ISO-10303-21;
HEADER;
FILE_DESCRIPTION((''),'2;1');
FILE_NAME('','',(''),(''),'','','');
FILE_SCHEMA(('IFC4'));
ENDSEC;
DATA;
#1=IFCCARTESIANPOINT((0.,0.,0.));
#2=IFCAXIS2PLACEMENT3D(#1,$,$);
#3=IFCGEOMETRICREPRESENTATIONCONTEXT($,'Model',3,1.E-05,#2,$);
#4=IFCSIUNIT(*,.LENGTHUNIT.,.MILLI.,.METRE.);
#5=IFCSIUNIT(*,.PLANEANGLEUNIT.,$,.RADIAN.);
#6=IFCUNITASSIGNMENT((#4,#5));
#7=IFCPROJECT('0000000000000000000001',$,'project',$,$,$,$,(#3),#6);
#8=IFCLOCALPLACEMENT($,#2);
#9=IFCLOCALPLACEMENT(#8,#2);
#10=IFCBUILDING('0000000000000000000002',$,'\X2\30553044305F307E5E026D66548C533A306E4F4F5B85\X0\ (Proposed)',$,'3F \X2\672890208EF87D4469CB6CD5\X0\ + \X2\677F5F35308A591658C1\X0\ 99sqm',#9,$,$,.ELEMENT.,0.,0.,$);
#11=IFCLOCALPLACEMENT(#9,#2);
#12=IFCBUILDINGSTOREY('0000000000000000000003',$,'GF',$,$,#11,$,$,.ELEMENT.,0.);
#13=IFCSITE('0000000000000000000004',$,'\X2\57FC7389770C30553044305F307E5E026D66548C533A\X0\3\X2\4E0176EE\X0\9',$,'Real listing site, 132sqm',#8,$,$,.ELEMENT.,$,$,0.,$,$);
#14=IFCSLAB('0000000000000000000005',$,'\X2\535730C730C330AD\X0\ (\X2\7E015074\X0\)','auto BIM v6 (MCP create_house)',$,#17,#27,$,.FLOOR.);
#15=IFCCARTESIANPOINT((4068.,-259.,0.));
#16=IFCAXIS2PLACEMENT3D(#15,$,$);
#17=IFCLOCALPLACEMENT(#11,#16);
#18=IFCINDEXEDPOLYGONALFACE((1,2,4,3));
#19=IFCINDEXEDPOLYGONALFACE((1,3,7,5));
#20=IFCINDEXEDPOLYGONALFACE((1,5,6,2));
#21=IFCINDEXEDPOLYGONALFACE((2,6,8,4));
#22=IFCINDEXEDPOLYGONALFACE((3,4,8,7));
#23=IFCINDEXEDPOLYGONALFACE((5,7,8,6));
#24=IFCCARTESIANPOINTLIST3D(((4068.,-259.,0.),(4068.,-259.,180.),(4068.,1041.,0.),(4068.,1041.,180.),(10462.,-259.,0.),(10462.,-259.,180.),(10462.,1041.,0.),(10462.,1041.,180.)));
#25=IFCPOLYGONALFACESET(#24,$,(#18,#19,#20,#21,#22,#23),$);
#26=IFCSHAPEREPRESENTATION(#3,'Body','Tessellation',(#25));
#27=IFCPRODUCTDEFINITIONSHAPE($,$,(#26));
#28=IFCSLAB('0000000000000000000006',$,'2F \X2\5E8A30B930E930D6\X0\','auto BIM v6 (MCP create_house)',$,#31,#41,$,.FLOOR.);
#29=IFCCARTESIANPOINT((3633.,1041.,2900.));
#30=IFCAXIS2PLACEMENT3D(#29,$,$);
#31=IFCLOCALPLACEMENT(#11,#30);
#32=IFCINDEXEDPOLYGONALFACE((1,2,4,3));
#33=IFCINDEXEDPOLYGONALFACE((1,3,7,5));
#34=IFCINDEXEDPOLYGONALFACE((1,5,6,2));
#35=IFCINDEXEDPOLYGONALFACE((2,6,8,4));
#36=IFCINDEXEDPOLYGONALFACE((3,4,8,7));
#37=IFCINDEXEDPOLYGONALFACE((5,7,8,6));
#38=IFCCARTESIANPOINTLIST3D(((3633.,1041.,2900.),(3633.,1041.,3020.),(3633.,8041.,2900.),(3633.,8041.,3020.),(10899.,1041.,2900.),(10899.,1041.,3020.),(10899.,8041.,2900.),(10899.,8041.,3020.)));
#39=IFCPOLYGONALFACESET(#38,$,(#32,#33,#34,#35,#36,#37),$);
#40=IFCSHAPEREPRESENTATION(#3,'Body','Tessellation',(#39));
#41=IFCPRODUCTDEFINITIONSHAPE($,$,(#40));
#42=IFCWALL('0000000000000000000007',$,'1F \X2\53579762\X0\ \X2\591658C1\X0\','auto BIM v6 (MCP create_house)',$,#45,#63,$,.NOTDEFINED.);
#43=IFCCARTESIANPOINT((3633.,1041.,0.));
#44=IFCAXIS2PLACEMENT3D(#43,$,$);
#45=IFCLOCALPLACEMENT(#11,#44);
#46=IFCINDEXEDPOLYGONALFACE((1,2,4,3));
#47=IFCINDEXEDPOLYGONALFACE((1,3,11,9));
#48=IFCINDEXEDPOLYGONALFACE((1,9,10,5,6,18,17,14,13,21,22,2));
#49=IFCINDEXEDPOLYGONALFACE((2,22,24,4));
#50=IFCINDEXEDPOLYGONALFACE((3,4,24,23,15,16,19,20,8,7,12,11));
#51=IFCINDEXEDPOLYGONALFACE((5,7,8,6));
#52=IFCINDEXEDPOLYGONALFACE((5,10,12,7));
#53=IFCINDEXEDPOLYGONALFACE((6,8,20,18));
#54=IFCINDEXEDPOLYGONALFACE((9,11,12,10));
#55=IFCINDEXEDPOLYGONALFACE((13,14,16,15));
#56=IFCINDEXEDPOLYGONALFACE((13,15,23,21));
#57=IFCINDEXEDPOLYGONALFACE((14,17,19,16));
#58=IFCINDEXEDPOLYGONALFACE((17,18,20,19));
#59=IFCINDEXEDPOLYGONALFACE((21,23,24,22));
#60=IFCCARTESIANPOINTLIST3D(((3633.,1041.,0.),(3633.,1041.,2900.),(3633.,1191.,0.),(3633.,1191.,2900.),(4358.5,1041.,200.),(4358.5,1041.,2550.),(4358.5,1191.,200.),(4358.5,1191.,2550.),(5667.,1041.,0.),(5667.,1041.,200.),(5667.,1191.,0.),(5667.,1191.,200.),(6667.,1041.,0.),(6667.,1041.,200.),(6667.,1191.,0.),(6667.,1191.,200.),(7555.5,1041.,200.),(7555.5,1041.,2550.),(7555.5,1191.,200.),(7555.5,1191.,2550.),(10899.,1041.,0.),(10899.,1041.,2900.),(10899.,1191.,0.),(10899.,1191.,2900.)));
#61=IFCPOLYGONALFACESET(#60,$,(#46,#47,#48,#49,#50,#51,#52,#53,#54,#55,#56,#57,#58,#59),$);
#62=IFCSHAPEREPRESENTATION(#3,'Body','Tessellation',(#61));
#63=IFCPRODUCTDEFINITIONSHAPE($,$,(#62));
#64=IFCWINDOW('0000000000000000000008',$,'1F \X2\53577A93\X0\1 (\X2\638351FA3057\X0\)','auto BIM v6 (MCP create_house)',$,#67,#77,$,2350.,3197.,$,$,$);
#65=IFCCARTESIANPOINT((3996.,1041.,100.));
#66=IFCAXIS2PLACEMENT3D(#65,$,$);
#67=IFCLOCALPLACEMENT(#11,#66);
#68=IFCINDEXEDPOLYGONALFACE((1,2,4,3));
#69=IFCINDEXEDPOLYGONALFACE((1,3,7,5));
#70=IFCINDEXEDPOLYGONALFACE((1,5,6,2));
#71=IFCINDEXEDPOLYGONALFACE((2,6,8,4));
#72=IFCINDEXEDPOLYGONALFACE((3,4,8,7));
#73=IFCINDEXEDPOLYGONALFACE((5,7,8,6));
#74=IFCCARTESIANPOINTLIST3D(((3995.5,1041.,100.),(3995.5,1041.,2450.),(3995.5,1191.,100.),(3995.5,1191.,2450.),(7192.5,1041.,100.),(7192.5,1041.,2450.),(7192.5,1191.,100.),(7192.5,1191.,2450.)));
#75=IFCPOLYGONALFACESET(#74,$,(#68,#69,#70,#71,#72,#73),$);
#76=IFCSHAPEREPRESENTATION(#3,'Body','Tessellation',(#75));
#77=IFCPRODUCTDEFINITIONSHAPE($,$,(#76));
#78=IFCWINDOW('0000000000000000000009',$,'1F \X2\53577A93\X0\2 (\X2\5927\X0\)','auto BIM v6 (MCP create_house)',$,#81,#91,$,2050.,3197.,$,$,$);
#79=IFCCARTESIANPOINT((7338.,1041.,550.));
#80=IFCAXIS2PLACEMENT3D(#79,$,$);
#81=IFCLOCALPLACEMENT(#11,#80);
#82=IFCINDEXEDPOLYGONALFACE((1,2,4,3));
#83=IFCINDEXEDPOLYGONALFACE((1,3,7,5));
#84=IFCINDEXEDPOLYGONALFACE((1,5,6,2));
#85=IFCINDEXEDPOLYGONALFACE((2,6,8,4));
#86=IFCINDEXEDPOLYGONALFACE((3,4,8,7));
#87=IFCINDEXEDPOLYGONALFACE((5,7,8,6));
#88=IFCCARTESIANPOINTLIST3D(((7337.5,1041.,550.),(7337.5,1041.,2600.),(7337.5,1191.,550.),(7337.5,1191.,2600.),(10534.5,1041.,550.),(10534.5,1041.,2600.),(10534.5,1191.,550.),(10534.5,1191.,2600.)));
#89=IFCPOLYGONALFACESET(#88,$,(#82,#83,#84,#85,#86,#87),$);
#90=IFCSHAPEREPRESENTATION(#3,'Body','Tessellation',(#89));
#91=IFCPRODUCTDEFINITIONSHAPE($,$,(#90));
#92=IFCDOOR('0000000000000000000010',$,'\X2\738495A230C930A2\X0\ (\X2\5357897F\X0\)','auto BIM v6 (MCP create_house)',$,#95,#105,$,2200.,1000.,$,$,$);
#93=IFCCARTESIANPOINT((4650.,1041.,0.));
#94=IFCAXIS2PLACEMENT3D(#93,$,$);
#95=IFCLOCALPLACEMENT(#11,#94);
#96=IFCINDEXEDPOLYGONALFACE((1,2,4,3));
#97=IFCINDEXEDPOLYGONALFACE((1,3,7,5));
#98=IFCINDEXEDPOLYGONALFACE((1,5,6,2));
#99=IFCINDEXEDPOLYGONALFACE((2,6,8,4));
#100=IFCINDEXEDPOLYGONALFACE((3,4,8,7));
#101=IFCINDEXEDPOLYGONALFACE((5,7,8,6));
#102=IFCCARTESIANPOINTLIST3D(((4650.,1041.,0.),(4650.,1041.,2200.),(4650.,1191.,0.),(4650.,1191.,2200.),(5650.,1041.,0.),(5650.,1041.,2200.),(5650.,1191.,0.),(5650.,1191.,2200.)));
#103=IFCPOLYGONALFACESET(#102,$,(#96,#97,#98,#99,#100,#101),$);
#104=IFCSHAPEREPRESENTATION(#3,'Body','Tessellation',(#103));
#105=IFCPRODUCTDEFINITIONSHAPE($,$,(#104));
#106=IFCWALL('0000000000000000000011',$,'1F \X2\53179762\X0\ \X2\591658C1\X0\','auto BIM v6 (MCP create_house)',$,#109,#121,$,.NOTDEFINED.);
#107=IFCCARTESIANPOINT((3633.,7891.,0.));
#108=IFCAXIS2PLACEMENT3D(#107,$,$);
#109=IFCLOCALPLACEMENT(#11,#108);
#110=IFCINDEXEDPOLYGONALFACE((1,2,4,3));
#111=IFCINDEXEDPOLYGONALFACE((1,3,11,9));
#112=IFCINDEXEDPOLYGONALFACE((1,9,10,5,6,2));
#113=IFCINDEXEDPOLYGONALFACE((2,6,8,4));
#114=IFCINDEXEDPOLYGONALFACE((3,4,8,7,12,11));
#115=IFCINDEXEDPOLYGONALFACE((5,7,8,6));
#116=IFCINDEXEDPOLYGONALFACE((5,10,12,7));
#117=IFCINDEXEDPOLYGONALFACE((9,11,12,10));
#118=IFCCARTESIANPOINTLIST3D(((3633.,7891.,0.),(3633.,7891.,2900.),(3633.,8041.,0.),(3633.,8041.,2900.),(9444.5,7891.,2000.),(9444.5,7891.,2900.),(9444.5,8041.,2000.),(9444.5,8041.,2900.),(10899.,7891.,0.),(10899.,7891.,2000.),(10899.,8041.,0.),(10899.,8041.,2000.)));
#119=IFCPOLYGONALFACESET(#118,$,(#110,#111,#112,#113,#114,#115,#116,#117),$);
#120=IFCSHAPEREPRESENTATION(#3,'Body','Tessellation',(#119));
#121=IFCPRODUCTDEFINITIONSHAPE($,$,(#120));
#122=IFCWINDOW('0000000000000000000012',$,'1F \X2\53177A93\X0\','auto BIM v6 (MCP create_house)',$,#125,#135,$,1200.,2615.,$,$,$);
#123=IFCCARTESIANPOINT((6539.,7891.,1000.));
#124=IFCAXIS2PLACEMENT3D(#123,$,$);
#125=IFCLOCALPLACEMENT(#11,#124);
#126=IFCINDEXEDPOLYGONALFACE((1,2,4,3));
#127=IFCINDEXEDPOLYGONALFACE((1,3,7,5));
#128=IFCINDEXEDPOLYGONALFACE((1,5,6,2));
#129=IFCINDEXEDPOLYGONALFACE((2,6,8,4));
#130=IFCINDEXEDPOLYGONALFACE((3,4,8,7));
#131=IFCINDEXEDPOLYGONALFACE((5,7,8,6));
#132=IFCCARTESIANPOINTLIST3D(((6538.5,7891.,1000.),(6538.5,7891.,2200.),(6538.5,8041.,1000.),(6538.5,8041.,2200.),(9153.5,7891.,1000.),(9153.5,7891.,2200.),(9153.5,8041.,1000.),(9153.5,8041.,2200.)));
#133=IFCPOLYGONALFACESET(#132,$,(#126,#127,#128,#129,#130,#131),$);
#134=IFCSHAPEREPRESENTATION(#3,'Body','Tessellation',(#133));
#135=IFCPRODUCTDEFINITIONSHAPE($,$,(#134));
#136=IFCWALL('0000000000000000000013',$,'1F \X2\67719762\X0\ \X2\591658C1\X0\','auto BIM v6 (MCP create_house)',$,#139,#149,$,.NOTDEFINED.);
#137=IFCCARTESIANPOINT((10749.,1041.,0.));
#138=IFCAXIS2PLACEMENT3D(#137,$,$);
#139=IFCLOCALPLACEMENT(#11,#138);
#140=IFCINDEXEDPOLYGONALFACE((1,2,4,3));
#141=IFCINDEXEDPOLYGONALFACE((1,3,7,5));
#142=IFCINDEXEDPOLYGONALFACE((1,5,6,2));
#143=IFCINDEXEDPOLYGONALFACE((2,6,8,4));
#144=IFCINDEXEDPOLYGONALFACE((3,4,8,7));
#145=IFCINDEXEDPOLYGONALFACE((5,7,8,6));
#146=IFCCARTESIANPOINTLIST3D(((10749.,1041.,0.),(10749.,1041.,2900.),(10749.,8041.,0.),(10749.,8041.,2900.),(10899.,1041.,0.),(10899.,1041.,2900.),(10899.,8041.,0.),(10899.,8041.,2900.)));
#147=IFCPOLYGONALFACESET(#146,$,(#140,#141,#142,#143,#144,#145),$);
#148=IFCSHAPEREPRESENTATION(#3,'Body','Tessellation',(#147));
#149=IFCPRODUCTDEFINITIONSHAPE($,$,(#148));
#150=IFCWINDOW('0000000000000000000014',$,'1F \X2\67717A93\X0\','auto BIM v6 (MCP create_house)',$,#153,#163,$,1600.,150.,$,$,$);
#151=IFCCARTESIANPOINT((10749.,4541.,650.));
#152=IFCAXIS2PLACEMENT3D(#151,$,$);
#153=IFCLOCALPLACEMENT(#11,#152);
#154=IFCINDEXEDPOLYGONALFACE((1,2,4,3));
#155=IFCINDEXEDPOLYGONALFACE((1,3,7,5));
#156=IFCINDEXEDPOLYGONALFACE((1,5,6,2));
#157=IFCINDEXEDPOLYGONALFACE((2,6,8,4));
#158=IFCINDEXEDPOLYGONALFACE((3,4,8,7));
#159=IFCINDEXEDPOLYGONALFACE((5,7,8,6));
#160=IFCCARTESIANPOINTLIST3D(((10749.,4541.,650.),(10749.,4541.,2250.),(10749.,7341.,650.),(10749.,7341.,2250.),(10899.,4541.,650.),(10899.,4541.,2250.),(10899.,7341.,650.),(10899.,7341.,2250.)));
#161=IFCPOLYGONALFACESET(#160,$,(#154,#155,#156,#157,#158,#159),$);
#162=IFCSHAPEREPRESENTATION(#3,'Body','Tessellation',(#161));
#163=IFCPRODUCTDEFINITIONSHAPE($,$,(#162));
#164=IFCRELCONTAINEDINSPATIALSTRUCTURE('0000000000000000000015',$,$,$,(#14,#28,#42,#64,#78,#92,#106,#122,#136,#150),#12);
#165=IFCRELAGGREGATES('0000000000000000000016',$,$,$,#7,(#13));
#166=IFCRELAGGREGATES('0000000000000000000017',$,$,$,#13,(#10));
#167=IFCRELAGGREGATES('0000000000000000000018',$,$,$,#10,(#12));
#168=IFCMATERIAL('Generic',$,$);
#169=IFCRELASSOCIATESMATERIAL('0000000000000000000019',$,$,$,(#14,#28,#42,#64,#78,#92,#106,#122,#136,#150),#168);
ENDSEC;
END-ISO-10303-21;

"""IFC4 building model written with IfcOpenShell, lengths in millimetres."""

from ifc_helpers import new_model, si_unit, frame, frame_2d, origin, place, context, project, spatial, rectangle, extrude, material, element, fill, save


model = new_model("IFC4")

# Units and contexts
model_context = context("Model", 3, precision=1e-05, world=origin())
ifc_project = project(units=[si_unit("LENGTHUNIT", "METRE", prefix="MILLI"), si_unit("PLANEANGLEUNIT", "RADIAN")], contexts=[model_context])

# Site, building, storey
site_placement = place(None, origin())
site = spatial("IfcSite", under=ifc_project, at=site_placement, Name="埼玉県さいたま市浦和区3丁目9", ObjectType="Real listing site, 132sqm", CompositionType="ELEMENT", RefElevation=0.0)
building_placement = place(site_placement, origin())
building = spatial("IfcBuilding", under=site, at=building_placement, Name="さいたま市浦和区の住宅 (Proposed)", ObjectType="3F 木造軸組構法 + 板張り外壁 99sqm", CompositionType="ELEMENT", ElevationOfRefHeight=0.0, ElevationOfTerrain=0.0)
storey_placement = place(building_placement, origin())
storey = spatial("IfcBuildingStorey", under=building, at=storey_placement, Name="GF", CompositionType="ELEMENT", Elevation=0.0)

# Slabs
ifc_material = material(Name="Generic")
slab_1_placement = place(storey_placement, frame((4068.0, -259.0, 0.0)))
element("IfcSlab", 1, at=slab_1_placement, inside=storey, material=ifc_material, Name="南デッキ (縁側)", Description="auto BIM v6 (MCP create_house)", PredefinedType="FLOOR", context=model_context, shape_type="SweptSolid", body=[
    extrude(rectangle(XDim=6394.0, YDim=1300.0, at=frame_2d((3197.0, 650.0))), frame((4068.0, -259.0, 0.0)), (0.0, 0.0, 1.0), 180.0),
])
slab_2_placement = place(storey_placement, frame((3633.0, 1041.0, 2900.0)))
element("IfcSlab", 2, at=slab_2_placement, inside=storey, material=ifc_material, Name="2F 床スラブ", Description="auto BIM v6 (MCP create_house)", PredefinedType="FLOOR", context=model_context, shape_type="SweptSolid", body=[
    extrude(rectangle(XDim=7266.0, YDim=7000.0, at=frame_2d((3633.0, 3500.0))), frame((3633.0, 1041.0, 2900.0)), (0.0, 0.0, 1.0), 120.0),
])

# Wall, openings, windows, door
wall_1_placement = place(storey_placement, frame((3633.0, 1041.0, 0.0)))
wall_1 = element("IfcWall", 3, at=wall_1_placement, inside=storey, material=ifc_material, Name="1F 南面 外壁", Description="auto BIM v6 (MCP create_house)", PredefinedType="NOTDEFINED", context=model_context, shape_type="SweptSolid", body=[
    extrude(rectangle(XDim=7266.0, YDim=150.0, at=frame_2d((3633.0, 75.0))), frame((3633.0, 1041.0, 0.0)), (0.0, 0.0, 1.0), 2900.0),
])
opening_1_placement = place(storey_placement, frame((3996.0, 1041.0, 100.0)))
opening_1 = element("IfcOpeningElement", 4, at=opening_1_placement, cuts=wall_1, PredefinedType="NOTDEFINED", context=model_context, shape_type="SweptSolid", body=[
    extrude(rectangle(XDim=3197.0, YDim=150.0, at=frame_2d((1598.0, 75.0))), frame((3996.0, 1041.0, 100.0)), (0.0, 0.0, 1.0), 2350.0),
])
opening_2_placement = place(storey_placement, frame((7338.0, 1041.0, 550.0)))
opening_2 = element("IfcOpeningElement", 5, at=opening_2_placement, cuts=wall_1, PredefinedType="NOTDEFINED", context=model_context, shape_type="SweptSolid", body=[
    extrude(rectangle(XDim=3197.0, YDim=150.0, at=frame_2d((1598.0, 75.0))), frame((7338.0, 1041.0, 550.0)), (0.0, 0.0, 1.0), 2050.0),
])
opening_3_placement = place(storey_placement, frame((4650.0, 1041.0, 0.0)))
opening_3 = element("IfcOpeningElement", 6, at=opening_3_placement, cuts=wall_1, PredefinedType="NOTDEFINED", context=model_context, shape_type="SweptSolid", body=[
    extrude(rectangle(XDim=1000.0, YDim=150.0, at=frame_2d((500.0, 75.0))), frame((4650.0, 1041.0, 0.0)), (0.0, 0.0, 1.0), 2200.0),
])
window_1_placement = place(storey_placement, frame((3996.0, 1041.0, 100.0)))
window_1 = element("IfcWindow", 7, at=window_1_placement, inside=storey, material=ifc_material, Name="1F 南窓1 (掃出し)", Description="auto BIM v6 (MCP create_house)", OverallHeight=2350.0, OverallWidth=3197.0, context=model_context, shape_type="SweptSolid", body=[
    extrude(rectangle(XDim=3197.0, YDim=150.0, at=frame_2d((1598.0, 75.0))), frame((3996.0, 1041.0, 100.0)), (0.0, 0.0, 1.0), 2350.0),
])
fill(opening_1, window_1)
window_2_placement = place(storey_placement, frame((7338.0, 1041.0, 550.0)))
window_2 = element("IfcWindow", 8, at=window_2_placement, inside=storey, material=ifc_material, Name="1F 南窓2 (大)", Description="auto BIM v6 (MCP create_house)", OverallHeight=2050.0, OverallWidth=3197.0, context=model_context, shape_type="SweptSolid", body=[
    extrude(rectangle(XDim=3197.0, YDim=150.0, at=frame_2d((1598.0, 75.0))), frame((7338.0, 1041.0, 550.0)), (0.0, 0.0, 1.0), 2050.0),
])
fill(opening_2, window_2)
door_placement = place(storey_placement, frame((4650.0, 1041.0, 0.0)))
door = element("IfcDoor", 9, at=door_placement, inside=storey, material=ifc_material, Name="玄関ドア (南西)", Description="auto BIM v6 (MCP create_house)", OverallHeight=2200.0, OverallWidth=1000.0, context=model_context, shape_type="SweptSolid", body=[
    extrude(rectangle(XDim=1000.0, YDim=150.0, at=frame_2d((500.0, 75.0))), frame((4650.0, 1041.0, 0.0)), (0.0, 0.0, 1.0), 2200.0),
])
fill(opening_3, door)

# Walls, openings, windows
wall_2_placement = place(storey_placement, frame((3633.0, 7891.0, 0.0)))
wall_2 = element("IfcWall", 10, at=wall_2_placement, inside=storey, material=ifc_material, Name="1F 北面 外壁", Description="auto BIM v6 (MCP create_house)", PredefinedType="NOTDEFINED", context=model_context, shape_type="SweptSolid", body=[
    extrude(rectangle(XDim=7266.0, YDim=150.0, at=frame_2d((3633.0, 75.0))), frame((3633.0, 7891.0, 0.0)), (0.0, 0.0, 1.0), 2900.0),
])
opening_4_placement = place(storey_placement, frame((6539.0, 7891.0, 1000.0)))
opening_4 = element("IfcOpeningElement", 11, at=opening_4_placement, cuts=wall_2, PredefinedType="NOTDEFINED", context=model_context, shape_type="SweptSolid", body=[
    extrude(rectangle(XDim=2615.0, YDim=150.0, at=frame_2d((1307.0, 75.0))), frame((6539.0, 7891.0, 1000.0)), (0.0, 0.0, 1.0), 1200.0),
])
window_3_placement = place(storey_placement, frame((6539.0, 7891.0, 1000.0)))
window_3 = element("IfcWindow", 12, at=window_3_placement, inside=storey, material=ifc_material, Name="1F 北窓", Description="auto BIM v6 (MCP create_house)", OverallHeight=1200.0, OverallWidth=2615.0, context=model_context, shape_type="SweptSolid", body=[
    extrude(rectangle(XDim=2615.0, YDim=150.0, at=frame_2d((1307.0, 75.0))), frame((6539.0, 7891.0, 1000.0)), (0.0, 0.0, 1.0), 1200.0),
])
fill(opening_4, window_3)
wall_3_placement = place(storey_placement, frame((10749.0, 1041.0, 0.0)))
wall_3 = element("IfcWall", 13, at=wall_3_placement, inside=storey, material=ifc_material, Name="1F 東面 外壁", Description="auto BIM v6 (MCP create_house)", PredefinedType="NOTDEFINED", context=model_context, shape_type="SweptSolid", body=[
    extrude(rectangle(XDim=150.0, YDim=7000.0, at=frame_2d((75.0, 3500.0))), frame((10749.0, 1041.0, 0.0)), (0.0, 0.0, 1.0), 2900.0),
])
opening_5_placement = place(storey_placement, frame((10749.0, 4541.0, 650.0)))
opening_5 = element("IfcOpeningElement", 14, at=opening_5_placement, cuts=wall_3, PredefinedType="NOTDEFINED", context=model_context, shape_type="SweptSolid", body=[
    extrude(rectangle(XDim=150.0, YDim=2800.0, at=frame_2d((75.0, 1400.0))), frame((10749.0, 4541.0, 650.0)), (0.0, 0.0, 1.0), 1600.0),
])
window_4_placement = place(storey_placement, frame((10749.0, 4541.0, 650.0)))
window_4 = element("IfcWindow", 15, at=window_4_placement, inside=storey, material=ifc_material, Name="1F 東窓", Description="auto BIM v6 (MCP create_house)", OverallHeight=1600.0, OverallWidth=150.0, context=model_context, shape_type="SweptSolid", body=[
    extrude(rectangle(XDim=150.0, YDim=2800.0, at=frame_2d((75.0, 1400.0))), frame((10749.0, 4541.0, 650.0)), (0.0, 0.0, 1.0), 1600.0),
])
fill(opening_5, window_4)

save(model, "model.ifc")
